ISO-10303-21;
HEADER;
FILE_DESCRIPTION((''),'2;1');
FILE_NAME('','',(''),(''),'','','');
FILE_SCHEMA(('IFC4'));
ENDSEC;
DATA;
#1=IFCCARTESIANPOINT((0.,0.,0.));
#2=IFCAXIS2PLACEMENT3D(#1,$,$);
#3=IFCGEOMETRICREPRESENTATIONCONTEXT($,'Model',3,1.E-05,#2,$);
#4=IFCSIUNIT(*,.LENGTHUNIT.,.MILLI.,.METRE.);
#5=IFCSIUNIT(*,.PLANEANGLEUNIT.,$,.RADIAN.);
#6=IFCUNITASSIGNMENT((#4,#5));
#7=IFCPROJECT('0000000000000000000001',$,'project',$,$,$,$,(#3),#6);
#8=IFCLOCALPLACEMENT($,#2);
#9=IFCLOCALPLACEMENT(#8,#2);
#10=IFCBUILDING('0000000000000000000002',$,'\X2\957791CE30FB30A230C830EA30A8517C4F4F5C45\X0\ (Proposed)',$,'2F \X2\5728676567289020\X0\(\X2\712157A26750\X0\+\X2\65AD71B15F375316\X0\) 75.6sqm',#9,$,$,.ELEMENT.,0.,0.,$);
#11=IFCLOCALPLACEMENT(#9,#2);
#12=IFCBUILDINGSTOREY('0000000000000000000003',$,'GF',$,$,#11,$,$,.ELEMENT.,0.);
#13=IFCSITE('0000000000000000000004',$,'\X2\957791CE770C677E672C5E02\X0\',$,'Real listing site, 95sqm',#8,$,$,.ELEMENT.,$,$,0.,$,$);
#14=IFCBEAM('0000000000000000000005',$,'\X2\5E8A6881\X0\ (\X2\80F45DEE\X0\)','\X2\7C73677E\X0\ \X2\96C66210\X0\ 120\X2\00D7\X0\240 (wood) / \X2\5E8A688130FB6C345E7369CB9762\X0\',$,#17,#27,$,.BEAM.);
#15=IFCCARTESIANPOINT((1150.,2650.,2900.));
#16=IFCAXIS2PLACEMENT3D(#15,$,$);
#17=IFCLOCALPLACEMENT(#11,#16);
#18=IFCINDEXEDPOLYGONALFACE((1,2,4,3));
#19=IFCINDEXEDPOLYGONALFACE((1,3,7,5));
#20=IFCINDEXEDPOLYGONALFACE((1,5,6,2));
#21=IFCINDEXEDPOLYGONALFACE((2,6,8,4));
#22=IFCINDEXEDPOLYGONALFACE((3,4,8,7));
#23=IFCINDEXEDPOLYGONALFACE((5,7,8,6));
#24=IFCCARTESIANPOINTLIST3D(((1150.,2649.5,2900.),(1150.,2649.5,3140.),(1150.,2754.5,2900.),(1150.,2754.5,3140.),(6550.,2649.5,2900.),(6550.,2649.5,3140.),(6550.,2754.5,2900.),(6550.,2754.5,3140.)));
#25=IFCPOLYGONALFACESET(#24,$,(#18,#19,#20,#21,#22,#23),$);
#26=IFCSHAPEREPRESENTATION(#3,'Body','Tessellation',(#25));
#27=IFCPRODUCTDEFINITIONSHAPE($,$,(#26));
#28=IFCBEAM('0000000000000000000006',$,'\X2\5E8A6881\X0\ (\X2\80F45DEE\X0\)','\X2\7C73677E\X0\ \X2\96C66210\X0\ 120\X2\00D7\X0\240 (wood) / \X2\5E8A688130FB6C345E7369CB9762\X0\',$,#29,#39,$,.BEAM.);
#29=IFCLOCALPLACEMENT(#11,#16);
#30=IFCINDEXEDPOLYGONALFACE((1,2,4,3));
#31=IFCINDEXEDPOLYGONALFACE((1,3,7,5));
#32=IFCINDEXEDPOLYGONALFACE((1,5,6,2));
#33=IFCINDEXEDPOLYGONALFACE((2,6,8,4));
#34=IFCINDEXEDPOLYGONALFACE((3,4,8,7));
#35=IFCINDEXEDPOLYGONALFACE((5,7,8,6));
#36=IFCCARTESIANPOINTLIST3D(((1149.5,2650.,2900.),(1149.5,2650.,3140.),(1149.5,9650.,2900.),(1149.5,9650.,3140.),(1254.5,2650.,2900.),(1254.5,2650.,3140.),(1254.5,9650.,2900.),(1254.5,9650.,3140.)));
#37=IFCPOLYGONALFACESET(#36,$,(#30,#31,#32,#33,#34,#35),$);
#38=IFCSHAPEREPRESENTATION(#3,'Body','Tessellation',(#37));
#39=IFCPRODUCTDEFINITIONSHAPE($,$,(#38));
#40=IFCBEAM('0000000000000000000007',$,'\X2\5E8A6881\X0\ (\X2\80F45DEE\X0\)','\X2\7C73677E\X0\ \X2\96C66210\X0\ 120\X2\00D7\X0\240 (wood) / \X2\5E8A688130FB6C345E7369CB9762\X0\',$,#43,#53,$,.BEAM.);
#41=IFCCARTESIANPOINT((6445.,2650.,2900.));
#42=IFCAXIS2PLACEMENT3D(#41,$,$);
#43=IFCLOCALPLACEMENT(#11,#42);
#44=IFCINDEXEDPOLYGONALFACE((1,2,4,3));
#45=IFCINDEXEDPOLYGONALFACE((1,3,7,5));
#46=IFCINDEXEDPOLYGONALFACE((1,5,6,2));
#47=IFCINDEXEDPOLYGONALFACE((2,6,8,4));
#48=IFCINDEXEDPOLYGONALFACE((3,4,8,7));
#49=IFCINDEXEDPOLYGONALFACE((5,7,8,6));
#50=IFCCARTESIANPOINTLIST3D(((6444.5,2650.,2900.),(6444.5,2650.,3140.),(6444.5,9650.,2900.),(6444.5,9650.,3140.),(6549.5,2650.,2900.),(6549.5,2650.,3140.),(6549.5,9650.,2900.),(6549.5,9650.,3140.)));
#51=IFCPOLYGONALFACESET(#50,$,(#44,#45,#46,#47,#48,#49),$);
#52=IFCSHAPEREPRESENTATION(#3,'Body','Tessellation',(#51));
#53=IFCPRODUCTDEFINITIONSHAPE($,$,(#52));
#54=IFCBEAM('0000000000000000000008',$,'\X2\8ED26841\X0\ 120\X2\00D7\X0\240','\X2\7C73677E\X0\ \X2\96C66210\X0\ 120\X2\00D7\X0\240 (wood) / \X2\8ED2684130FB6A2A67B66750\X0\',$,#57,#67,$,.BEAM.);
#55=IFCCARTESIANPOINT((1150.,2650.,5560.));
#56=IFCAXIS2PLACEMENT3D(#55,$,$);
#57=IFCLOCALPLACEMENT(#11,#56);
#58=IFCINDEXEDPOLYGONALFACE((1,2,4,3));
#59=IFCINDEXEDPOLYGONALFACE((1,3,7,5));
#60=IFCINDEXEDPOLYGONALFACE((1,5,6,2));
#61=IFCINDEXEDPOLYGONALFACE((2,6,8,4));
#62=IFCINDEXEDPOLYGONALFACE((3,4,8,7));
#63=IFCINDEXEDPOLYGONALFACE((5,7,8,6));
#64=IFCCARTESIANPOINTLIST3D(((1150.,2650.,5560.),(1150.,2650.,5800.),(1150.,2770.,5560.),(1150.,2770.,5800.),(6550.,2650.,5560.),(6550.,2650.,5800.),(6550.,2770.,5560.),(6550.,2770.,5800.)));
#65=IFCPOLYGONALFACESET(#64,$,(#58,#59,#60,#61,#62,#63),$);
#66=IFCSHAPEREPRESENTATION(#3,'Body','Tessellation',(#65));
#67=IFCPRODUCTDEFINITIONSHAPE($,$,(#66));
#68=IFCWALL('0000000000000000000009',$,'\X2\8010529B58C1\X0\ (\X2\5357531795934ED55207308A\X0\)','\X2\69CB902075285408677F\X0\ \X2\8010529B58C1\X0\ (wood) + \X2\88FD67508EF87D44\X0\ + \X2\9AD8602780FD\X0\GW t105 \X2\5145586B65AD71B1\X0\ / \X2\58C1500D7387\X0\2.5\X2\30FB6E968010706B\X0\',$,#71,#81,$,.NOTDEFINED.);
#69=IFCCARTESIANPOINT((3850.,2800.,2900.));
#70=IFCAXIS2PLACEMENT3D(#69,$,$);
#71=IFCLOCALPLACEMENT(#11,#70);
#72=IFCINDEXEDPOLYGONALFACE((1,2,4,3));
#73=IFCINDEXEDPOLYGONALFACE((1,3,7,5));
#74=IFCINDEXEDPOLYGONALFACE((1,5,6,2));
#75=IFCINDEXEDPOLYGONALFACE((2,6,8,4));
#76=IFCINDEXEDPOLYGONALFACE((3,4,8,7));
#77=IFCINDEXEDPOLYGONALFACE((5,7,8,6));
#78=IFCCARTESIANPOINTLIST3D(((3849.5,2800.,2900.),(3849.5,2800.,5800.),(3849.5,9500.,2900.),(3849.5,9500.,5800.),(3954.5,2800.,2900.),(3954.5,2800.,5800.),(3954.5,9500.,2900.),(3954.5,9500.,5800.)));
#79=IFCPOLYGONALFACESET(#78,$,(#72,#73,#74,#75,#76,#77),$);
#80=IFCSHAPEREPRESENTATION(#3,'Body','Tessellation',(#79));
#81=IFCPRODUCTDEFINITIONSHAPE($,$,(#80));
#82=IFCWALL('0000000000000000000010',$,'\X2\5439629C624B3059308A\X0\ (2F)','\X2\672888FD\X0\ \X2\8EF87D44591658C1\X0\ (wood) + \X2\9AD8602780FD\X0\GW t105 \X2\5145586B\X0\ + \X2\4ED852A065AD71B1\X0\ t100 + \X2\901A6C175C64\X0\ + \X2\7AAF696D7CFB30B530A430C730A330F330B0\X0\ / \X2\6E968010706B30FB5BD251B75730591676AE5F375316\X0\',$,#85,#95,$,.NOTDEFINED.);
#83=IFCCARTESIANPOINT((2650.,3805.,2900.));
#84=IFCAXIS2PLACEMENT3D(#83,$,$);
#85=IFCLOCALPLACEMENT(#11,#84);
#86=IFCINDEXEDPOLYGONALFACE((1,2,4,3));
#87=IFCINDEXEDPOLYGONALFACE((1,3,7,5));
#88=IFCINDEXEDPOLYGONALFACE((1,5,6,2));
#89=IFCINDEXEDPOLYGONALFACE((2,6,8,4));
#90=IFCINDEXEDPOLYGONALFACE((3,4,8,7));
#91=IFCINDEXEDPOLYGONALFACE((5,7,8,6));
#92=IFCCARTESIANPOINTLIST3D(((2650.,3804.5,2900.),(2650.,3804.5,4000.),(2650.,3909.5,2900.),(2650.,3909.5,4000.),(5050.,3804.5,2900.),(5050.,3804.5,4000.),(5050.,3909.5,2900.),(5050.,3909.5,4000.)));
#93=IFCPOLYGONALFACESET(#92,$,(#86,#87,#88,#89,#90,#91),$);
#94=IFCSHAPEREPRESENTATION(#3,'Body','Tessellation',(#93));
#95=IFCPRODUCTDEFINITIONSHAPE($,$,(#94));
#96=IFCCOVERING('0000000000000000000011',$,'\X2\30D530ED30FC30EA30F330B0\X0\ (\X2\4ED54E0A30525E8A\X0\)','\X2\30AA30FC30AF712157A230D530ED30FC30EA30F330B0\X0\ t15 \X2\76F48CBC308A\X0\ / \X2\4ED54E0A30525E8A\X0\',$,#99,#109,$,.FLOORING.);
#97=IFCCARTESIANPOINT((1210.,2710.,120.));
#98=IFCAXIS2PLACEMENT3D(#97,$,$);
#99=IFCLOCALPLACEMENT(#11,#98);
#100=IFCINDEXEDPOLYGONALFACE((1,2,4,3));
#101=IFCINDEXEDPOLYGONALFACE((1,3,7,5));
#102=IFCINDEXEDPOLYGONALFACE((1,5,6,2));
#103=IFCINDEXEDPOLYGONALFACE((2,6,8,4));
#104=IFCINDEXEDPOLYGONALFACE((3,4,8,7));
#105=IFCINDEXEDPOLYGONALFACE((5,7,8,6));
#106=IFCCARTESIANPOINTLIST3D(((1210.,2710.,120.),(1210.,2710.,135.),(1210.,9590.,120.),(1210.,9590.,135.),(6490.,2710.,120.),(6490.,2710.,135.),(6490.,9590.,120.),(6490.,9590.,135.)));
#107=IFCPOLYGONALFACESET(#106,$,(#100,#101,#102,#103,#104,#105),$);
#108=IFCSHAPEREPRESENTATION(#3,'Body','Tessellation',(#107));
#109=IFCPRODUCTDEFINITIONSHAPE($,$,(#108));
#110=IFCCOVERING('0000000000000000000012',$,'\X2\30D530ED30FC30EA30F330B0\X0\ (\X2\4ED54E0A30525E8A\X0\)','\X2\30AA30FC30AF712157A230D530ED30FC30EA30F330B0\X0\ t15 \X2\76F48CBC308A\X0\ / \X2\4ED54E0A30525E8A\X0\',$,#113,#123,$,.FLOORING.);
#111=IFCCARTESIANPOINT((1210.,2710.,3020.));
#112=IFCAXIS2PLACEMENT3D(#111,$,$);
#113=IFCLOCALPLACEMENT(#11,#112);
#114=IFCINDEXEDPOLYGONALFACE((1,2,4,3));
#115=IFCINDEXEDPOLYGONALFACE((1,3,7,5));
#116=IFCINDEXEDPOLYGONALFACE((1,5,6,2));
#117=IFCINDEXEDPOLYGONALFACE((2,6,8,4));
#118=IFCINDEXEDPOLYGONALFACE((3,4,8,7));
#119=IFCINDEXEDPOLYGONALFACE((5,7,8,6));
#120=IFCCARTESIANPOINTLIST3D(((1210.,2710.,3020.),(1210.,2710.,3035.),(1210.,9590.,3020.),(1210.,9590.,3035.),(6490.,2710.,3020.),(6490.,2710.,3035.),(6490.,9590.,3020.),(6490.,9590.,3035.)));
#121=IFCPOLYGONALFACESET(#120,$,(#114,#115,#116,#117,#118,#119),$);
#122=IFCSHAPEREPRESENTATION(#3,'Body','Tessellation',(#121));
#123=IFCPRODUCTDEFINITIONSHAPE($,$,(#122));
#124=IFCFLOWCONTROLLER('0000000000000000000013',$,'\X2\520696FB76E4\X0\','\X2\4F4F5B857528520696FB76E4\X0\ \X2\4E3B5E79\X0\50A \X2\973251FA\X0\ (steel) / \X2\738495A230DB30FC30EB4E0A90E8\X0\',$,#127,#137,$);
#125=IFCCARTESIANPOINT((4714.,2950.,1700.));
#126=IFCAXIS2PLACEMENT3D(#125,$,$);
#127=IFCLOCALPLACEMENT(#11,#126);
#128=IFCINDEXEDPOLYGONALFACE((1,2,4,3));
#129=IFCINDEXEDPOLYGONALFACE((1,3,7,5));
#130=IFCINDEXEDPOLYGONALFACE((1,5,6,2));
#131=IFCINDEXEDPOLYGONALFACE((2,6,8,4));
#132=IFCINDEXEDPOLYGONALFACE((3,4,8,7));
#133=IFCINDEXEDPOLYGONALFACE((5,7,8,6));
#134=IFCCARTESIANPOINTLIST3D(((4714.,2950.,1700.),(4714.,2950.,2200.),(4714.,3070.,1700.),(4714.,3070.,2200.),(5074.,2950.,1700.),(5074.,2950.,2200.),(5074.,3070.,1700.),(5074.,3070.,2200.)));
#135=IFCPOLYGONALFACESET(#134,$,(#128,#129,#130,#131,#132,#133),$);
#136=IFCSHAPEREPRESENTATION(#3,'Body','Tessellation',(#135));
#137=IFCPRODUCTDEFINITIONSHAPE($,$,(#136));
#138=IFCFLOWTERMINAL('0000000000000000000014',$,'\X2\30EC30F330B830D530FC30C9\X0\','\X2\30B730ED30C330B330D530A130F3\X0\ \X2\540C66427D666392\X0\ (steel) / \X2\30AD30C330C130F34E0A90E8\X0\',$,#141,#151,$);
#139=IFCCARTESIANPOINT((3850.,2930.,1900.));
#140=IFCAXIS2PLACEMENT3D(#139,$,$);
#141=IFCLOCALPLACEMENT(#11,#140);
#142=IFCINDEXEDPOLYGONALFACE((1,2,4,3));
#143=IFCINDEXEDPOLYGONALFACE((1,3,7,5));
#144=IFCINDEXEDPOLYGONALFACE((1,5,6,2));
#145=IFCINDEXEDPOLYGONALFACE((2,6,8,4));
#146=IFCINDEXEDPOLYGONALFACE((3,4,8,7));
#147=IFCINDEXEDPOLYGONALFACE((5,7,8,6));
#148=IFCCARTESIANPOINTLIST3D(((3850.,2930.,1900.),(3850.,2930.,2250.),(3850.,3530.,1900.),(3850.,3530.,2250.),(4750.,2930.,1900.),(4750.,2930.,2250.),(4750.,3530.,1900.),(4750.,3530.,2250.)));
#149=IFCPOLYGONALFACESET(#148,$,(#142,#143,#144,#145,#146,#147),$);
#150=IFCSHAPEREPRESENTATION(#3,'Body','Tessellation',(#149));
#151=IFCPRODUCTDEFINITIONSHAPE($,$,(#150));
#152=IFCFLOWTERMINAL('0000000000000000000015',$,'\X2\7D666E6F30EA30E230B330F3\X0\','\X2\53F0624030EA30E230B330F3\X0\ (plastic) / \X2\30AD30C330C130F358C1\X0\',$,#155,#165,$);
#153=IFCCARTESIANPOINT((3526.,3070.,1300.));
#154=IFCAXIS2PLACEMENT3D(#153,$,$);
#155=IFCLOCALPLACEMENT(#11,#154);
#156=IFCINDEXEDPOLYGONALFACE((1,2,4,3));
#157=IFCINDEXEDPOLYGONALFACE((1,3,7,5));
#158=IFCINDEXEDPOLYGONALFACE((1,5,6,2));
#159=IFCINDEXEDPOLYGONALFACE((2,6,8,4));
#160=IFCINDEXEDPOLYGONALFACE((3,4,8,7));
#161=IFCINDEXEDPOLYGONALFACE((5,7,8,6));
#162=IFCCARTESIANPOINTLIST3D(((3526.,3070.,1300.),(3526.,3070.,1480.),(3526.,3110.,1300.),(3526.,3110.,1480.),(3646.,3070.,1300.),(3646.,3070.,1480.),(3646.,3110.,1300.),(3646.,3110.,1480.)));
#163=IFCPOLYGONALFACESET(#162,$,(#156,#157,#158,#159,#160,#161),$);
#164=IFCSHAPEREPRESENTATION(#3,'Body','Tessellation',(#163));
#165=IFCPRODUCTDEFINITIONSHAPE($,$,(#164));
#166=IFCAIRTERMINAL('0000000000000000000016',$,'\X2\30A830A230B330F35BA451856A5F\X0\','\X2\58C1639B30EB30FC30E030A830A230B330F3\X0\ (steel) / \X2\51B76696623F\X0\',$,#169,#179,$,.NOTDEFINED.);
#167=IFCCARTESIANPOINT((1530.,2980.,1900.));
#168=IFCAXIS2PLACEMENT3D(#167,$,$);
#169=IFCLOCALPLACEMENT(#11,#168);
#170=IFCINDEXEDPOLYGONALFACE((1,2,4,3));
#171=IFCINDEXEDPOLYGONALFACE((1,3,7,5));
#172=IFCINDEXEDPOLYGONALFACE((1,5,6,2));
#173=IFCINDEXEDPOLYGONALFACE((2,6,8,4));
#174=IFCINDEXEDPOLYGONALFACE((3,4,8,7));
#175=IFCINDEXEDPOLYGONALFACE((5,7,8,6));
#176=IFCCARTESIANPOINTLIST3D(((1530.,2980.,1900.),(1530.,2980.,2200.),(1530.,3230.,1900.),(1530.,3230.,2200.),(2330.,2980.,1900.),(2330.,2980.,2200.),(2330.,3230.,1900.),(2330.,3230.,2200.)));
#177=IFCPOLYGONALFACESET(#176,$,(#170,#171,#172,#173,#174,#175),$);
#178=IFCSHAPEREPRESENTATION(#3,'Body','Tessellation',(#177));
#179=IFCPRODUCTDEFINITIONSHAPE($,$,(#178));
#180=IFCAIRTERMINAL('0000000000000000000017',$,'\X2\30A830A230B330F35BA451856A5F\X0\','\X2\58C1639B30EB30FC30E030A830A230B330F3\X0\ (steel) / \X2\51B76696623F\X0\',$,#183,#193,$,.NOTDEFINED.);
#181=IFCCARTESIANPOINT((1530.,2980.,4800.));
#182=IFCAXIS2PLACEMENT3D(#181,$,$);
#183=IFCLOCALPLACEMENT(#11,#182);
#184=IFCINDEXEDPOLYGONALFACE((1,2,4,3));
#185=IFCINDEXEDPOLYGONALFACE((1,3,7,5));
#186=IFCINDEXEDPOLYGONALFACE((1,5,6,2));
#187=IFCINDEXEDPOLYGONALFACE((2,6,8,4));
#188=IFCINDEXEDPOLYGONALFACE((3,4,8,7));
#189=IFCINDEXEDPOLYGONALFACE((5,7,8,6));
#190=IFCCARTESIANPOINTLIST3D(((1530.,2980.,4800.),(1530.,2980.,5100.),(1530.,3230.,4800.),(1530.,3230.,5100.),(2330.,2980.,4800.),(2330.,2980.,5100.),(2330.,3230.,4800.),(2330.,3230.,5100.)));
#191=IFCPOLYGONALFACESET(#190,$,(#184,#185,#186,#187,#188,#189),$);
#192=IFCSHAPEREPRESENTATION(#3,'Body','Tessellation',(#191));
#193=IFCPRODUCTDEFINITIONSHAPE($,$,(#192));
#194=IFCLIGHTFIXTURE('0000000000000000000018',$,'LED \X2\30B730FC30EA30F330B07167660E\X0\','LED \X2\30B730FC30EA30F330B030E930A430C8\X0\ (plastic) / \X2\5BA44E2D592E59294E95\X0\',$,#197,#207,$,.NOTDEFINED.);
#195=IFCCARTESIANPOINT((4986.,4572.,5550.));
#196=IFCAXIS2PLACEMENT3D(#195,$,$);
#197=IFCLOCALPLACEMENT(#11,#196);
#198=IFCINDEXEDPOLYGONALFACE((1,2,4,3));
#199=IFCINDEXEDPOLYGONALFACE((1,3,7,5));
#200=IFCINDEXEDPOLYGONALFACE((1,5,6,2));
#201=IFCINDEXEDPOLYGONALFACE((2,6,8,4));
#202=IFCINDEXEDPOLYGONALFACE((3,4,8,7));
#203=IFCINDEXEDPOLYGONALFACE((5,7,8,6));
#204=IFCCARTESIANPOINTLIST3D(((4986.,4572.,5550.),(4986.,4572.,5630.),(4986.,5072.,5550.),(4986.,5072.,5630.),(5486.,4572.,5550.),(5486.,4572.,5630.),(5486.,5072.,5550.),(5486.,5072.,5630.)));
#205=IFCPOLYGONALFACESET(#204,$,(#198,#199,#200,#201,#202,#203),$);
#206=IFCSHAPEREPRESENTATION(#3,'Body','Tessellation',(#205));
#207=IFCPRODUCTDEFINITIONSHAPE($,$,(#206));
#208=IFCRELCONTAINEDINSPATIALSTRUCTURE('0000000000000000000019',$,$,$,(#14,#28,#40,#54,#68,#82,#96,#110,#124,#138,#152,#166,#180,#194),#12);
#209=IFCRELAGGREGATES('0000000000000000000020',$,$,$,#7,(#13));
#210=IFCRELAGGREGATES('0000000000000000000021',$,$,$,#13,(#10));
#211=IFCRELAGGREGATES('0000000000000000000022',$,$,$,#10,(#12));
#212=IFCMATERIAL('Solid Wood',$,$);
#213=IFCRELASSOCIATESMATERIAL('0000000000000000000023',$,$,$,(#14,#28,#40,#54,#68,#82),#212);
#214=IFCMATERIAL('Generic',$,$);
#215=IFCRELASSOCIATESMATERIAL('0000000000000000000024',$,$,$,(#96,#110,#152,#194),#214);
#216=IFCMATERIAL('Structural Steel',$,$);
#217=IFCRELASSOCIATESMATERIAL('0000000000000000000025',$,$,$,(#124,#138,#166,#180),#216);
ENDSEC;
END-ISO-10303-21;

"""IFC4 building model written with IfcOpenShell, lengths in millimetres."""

from ifc_helpers import new_model, si_unit, frame, frame_2d, origin, place, context, project, spatial, rectangle, extrude, material, element, save


model = new_model("IFC4")

# Units and contexts
model_context = context("Model", 3, precision=1e-05, world=origin())
ifc_project = project(units=[si_unit("LENGTHUNIT", "METRE", prefix="MILLI"), si_unit("PLANEANGLEUNIT", "RADIAN")], contexts=[model_context])

# Site, building, storey
site_placement = place(None, origin())
site = spatial("IfcSite", under=ifc_project, at=site_placement, Name="長野県松本市", ObjectType="Real listing site, 95sqm", CompositionType="ELEMENT", RefElevation=0.0)
building_placement = place(site_placement, origin())
building = spatial("IfcBuilding", under=site, at=building_placement, Name="長野・アトリエ兼住居 (Proposed)", ObjectType="2F 在来木造(無垢材+断熱強化) 75.6sqm", CompositionType="ELEMENT", ElevationOfRefHeight=0.0, ElevationOfTerrain=0.0)
storey_placement = place(building_placement, origin())
storey = spatial("IfcBuildingStorey", under=building, at=storey_placement, Name="GF", CompositionType="ELEMENT", Elevation=0.0)

# Shared definitions
ifc_material_1 = material(Name="Solid Wood")

# Beams
beam_1_placement = place(storey_placement, frame((1150.0, 2650.0, 2900.0)))
element("IfcBeam", 1, at=beam_1_placement, inside=storey, material=ifc_material_1, Name="床梁 (胴差)", Description="米松 集成 120×240 (wood) / 床梁・水平構面", PredefinedType="BEAM", context=model_context, shape_type="SweptSolid", body=[
    extrude(rectangle(XDim=5400.0, YDim=105.0, at=frame_2d((2700.0, 52.0))), frame((1150.0, 2650.0, 2900.0)), (0.0, 0.0, 1.0), 240.0),
])
beam_2_placement = place(storey_placement, frame((1150.0, 2650.0, 2900.0)))
element("IfcBeam", 2, at=beam_2_placement, inside=storey, material=ifc_material_1, Name="床梁 (胴差)", Description="米松 集成 120×240 (wood) / 床梁・水平構面", PredefinedType="BEAM", context=model_context, shape_type="SweptSolid", body=[
    extrude(rectangle(XDim=105.0, YDim=7000.0, at=frame_2d((52.0, 3500.0))), frame((1150.0, 2650.0, 2900.0)), (0.0, 0.0, 1.0), 240.0),
])
beam_3_placement = place(storey_placement, frame((6445.0, 2650.0, 2900.0)))
element("IfcBeam", 3, at=beam_3_placement, inside=storey, material=ifc_material_1, Name="床梁 (胴差)", Description="米松 集成 120×240 (wood) / 床梁・水平構面", PredefinedType="BEAM", context=model_context, shape_type="SweptSolid", body=[
    extrude(rectangle(XDim=105.0, YDim=7000.0, at=frame_2d((52.0, 3500.0))), frame((6445.0, 2650.0, 2900.0)), (0.0, 0.0, 1.0), 240.0),
])
beam_4_placement = place(storey_placement, frame((1150.0, 2650.0, 5560.0)))
element("IfcBeam", 4, at=beam_4_placement, inside=storey, material=ifc_material_1, Name="軒桁 120×240", Description="米松 集成 120×240 (wood) / 軒桁・横架材", PredefinedType="BEAM", context=model_context, shape_type="SweptSolid", body=[
    extrude(rectangle(XDim=5400.0, YDim=120.0, at=frame_2d((2700.0, 60.0))), frame((1150.0, 2650.0, 5560.0)), (0.0, 0.0, 1.0), 240.0),
])

# Walls
wall_1_placement = place(storey_placement, frame((3850.0, 2800.0, 2900.0)))
element("IfcWall", 5, at=wall_1_placement, inside=storey, material=ifc_material_1, Name="耐力壁 (南北間仕切り)", Description="構造用合板 耐力壁 (wood) + 製材軸組 + 高性能GW t105 充填断熱 / 壁倍率2.5・準耐火", PredefinedType="NOTDEFINED", context=model_context, shape_type="SweptSolid", body=[
    extrude(rectangle(XDim=105.0, YDim=6700.0, at=frame_2d((52.0, 3350.0))), frame((3850.0, 2800.0, 2900.0)), (0.0, 0.0, 1.0), 2900.0),
])
wall_2_placement = place(storey_placement, frame((2650.0, 3805.0, 2900.0)))
element("IfcWall", 6, at=wall_2_placement, inside=storey, material=ifc_material_1, Name="吹抜手すり (2F)", Description="木製 軸組外壁 (wood) + 高性能GW t105 充填 + 付加断熱 t100 + 通気層 + 窯業系サイディング / 準耐火・寒冷地外皮強化", PredefinedType="NOTDEFINED", context=model_context, shape_type="SweptSolid", body=[
    extrude(rectangle(XDim=2400.0, YDim=105.0, at=frame_2d((1200.0, 52.0))), frame((2650.0, 3805.0, 2900.0)), (0.0, 0.0, 1.0), 1100.0),
])

# Coverings
ifc_material_2 = material(Name="Generic")
covering_1_placement = place(storey_placement, frame((1210.0, 2710.0, 120.0)))
element("IfcCovering", 7, at=covering_1_placement, inside=storey, material=ifc_material_2, Name="フローリング (仕上げ床)", Description="オーク無垢フローリング t15 直貼り / 仕上げ床", PredefinedType="FLOORING", context=model_context, shape_type="SweptSolid", body=[
    extrude(rectangle(XDim=5280.0, YDim=6880.0, at=frame_2d((2640.0, 3440.0))), frame((1210.0, 2710.0, 120.0)), (0.0, 0.0, 1.0), 15.0),
])
covering_2_placement = place(storey_placement, frame((1210.0, 2710.0, 3020.0)))
element("IfcCovering", 8, at=covering_2_placement, inside=storey, material=ifc_material_2, Name="フローリング (仕上げ床)", Description="オーク無垢フローリング t15 直貼り / 仕上げ床", PredefinedType="FLOORING", context=model_context, shape_type="SweptSolid", body=[
    extrude(rectangle(XDim=5280.0, YDim=6880.0, at=frame_2d((2640.0, 3440.0))), frame((1210.0, 2710.0, 3020.0)), (0.0, 0.0, 1.0), 15.0),
])

# Flow controller
ifc_material_3 = material(Name="Structural Steel")
flow_controller_placement = place(storey_placement, frame((4714.0, 2950.0, 1700.0)))
element("IfcFlowController", 9, at=flow_controller_placement, inside=storey, material=ifc_material_3, Name="分電盤", Description="住宅用分電盤 主幹50A 露出 (steel) / 玄関ホール上部", context=model_context, shape_type="SweptSolid", body=[
    extrude(rectangle(XDim=360.0, YDim=120.0, at=frame_2d((180.0, 60.0))), frame((4714.0, 2950.0, 1700.0)), (0.0, 0.0, 1.0), 500.0),
])

# Flow terminals
flow_terminal_1_placement = place(storey_placement, frame((3850.0, 2930.0, 1900.0)))
element("IfcFlowTerminal", 10, at=flow_terminal_1_placement, inside=storey, material=ifc_material_3, Name="レンジフード", Description="シロッコファン 同時給排 (steel) / キッチン上部", context=model_context, shape_type="SweptSolid", body=[
    extrude(rectangle(XDim=900.0, YDim=600.0, at=frame_2d((450.0, 300.0))), frame((3850.0, 2930.0, 1900.0)), (0.0, 0.0, 1.0), 350.0),
])
flow_terminal_2_placement = place(storey_placement, frame((3526.0, 3070.0, 1300.0)))
element("IfcFlowTerminal", 11, at=flow_terminal_2_placement, inside=storey, material=ifc_material_2, Name="給湯リモコン", Description="台所リモコン (plastic) / キッチン壁", context=model_context, shape_type="SweptSolid", body=[
    extrude(rectangle(XDim=120.0, YDim=40.0, at=frame_2d((60.0, 20.0))), frame((3526.0, 3070.0, 1300.0)), (0.0, 0.0, 1.0), 180.0),
])

# Air terminals
air_terminal_1_placement = place(storey_placement, frame((1530.0, 2980.0, 1900.0)))
element("IfcAirTerminal", 12, at=air_terminal_1_placement, inside=storey, material=ifc_material_3, Name="エアコン室内機", Description="壁掛ルームエアコン (steel) / 冷暖房", PredefinedType="NOTDEFINED", context=model_context, shape_type="SweptSolid", body=[
    extrude(rectangle(XDim=800.0, YDim=250.0, at=frame_2d((400.0, 125.0))), frame((1530.0, 2980.0, 1900.0)), (0.0, 0.0, 1.0), 300.0),
])
air_terminal_2_placement = place(storey_placement, frame((1530.0, 2980.0, 4800.0)))
element("IfcAirTerminal", 13, at=air_terminal_2_placement, inside=storey, material=ifc_material_3, Name="エアコン室内機", Description="壁掛ルームエアコン (steel) / 冷暖房", PredefinedType="NOTDEFINED", context=model_context, shape_type="SweptSolid", body=[
    extrude(rectangle(XDim=800.0, YDim=250.0, at=frame_2d((400.0, 125.0))), frame((1530.0, 2980.0, 4800.0)), (0.0, 0.0, 1.0), 300.0),
])

# Light fixture
light_fixture_placement = place(storey_placement, frame((4986.0, 4572.0, 5550.0)))
element("IfcLightFixture", 14, at=light_fixture_placement, inside=storey, material=ifc_material_2, Name="LED シーリング照明", Description="LED シーリングライト (plastic) / 室中央天井", PredefinedType="NOTDEFINED", context=model_context, shape_type="SweptSolid", body=[
    extrude(rectangle(XDim=500.0, YDim=500.0, at=frame_2d((250.0, 250.0))), frame((4986.0, 4572.0, 5550.0)), (0.0, 0.0, 1.0), 80.0),
])

save(model, "model.ifc")
